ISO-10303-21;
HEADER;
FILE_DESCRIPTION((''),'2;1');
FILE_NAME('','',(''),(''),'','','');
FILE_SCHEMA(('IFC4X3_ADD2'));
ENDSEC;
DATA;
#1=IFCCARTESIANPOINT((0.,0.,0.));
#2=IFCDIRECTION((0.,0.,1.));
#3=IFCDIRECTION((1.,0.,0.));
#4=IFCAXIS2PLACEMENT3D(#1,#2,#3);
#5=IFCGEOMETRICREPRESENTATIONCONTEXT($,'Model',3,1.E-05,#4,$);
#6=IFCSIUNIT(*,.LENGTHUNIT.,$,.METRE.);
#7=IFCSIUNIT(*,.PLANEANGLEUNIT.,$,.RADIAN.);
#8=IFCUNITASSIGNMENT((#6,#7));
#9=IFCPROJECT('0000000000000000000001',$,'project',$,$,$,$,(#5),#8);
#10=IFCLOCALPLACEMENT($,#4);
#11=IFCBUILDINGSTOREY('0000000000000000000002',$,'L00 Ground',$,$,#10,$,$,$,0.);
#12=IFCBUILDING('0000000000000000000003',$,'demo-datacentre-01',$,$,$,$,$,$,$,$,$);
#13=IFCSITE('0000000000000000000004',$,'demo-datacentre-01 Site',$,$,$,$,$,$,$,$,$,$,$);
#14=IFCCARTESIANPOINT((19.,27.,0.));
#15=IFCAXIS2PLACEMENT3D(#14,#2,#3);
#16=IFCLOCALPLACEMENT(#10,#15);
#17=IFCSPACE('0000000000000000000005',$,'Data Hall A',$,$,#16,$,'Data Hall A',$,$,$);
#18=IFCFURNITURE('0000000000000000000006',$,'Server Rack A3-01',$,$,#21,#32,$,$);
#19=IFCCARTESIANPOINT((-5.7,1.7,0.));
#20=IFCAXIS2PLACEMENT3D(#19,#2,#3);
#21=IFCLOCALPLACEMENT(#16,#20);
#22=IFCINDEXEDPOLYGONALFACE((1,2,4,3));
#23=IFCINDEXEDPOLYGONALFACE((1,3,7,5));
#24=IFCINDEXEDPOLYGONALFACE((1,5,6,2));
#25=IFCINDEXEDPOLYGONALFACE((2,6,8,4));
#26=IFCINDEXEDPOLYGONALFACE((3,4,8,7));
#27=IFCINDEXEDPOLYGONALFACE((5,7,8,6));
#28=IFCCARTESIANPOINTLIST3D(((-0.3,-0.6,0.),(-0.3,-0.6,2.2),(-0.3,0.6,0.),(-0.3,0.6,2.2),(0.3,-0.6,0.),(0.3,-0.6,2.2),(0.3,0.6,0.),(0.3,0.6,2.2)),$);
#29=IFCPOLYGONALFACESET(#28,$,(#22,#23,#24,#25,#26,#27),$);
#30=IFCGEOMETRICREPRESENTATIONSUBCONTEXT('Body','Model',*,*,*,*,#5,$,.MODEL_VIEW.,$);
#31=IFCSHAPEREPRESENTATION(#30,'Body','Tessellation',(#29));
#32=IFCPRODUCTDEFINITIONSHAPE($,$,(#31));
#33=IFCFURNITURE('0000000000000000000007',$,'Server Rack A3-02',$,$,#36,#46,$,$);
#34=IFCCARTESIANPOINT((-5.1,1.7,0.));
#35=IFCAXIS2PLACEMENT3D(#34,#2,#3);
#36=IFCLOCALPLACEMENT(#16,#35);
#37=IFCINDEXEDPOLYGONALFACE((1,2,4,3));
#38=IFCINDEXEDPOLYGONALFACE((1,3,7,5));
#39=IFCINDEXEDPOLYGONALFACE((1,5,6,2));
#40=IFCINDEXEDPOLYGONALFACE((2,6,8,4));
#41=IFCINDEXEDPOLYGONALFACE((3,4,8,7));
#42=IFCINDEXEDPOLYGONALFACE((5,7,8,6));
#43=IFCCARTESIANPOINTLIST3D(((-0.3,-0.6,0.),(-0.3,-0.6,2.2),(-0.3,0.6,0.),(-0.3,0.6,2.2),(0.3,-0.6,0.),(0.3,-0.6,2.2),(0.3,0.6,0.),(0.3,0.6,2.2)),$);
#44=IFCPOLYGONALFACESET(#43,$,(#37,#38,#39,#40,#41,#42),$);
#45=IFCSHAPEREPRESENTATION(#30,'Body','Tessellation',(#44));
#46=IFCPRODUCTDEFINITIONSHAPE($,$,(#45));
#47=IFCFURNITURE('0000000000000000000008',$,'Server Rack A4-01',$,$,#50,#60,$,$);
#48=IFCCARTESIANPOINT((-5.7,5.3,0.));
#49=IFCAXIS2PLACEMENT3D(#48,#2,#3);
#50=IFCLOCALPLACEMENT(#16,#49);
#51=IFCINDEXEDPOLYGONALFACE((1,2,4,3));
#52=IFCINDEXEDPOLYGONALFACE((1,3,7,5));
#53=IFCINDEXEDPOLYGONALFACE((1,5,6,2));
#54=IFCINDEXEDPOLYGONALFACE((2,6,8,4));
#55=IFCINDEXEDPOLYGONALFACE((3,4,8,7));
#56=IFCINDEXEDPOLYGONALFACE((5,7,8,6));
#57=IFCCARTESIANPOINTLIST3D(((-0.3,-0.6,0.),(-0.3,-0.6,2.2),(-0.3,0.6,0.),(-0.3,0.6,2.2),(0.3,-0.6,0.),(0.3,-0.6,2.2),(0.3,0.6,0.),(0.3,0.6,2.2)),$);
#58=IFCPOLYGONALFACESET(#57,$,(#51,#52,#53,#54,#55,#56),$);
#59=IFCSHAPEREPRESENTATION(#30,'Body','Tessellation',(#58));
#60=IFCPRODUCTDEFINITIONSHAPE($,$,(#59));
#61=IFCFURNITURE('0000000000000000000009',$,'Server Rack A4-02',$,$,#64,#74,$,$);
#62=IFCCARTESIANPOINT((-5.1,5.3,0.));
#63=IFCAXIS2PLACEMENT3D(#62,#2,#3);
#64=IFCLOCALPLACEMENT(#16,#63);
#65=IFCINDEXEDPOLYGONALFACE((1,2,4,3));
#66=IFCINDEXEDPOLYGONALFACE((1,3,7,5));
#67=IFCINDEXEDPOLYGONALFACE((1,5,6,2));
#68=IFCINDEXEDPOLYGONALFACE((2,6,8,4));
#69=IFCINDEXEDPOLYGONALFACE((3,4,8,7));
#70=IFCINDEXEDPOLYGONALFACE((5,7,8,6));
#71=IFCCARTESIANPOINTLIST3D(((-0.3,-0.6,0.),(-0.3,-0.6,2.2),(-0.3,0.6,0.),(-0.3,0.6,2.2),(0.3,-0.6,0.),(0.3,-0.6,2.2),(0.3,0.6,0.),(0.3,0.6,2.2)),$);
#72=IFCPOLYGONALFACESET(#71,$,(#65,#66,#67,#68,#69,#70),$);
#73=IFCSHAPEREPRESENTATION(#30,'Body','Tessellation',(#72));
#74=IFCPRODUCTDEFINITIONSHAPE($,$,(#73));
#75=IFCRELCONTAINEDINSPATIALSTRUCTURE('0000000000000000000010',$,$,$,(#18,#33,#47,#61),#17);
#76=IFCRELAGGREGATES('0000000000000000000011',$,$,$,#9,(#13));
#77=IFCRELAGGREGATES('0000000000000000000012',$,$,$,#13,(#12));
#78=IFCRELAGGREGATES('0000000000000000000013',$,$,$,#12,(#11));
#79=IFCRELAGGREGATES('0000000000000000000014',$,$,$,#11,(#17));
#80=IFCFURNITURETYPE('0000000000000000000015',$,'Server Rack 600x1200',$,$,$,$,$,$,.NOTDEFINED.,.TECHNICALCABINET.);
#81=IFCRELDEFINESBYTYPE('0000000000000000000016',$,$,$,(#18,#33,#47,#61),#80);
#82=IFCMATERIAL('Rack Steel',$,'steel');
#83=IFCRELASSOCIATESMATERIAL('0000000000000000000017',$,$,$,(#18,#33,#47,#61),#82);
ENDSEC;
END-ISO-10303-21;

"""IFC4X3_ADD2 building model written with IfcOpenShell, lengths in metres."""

from ifc_helpers import new_model, si_unit, frame, origin_with_axes, place, context, subcontext, project, spatial, rectangle, extrude, material, type_object, element, save


model = new_model("IFC4X3_ADD2")

# Units and contexts
model_context = context("Model", 3, precision=1e-05, world=origin_with_axes())
body_context = subcontext(model_context, "Body", "Model", "MODEL_VIEW")
ifc_project = project(units=[si_unit("LENGTHUNIT", "METRE"), si_unit("PLANEANGLEUNIT", "RADIAN")], contexts=[model_context])

# Site, building, storey
site = spatial("IfcSite", under=ifc_project, Name="demo-datacentre-01 Site")
building = spatial("IfcBuilding", under=site, Name="demo-datacentre-01")
storey_placement = place(None, origin_with_axes())
storey = spatial("IfcBuildingStorey", under=building, at=storey_placement, Name="L00 Ground", Elevation=0.0)

# Shared definitions
space_placement = place(storey_placement, frame((19.0, 27.0, 0.0), z_axis=(0.0, 0.0, 1.0), x_axis=(1.0, 0.0, 0.0)))
space = spatial("IfcSpace", under=storey, at=space_placement, Name="Data Hall A", LongName="Data Hall A")

# Furniture
ifc_material_1 = material(Name="Rack Steel", Category="steel")
furniture_type = type_object("IfcFurnitureType", Name="Server Rack 600x1200", AssemblyPlace="NOTDEFINED", PredefinedType="TECHNICALCABINET")
for number, where, z_axis, x_axis, name in (
    (1, (-5.7, 1.7, 0.0), (0.0, 0.0, 1.0), (1.0, 0.0, 0.0), "Server Rack A3-01"),
    (2, (-5.1, 1.7, 0.0), (0.0, 0.0, 1.0), (1.0, 0.0, 0.0), "Server Rack A3-02"),
    (3, (-5.7, 5.3, 0.0), (0.0, 0.0, 1.0), (1.0, 0.0, 0.0), "Server Rack A4-01"),
    (4, (-5.1, 5.3, 0.0), (0.0, 0.0, 1.0), (1.0, 0.0, 0.0), "Server Rack A4-02"),
):
    element("IfcFurniture", number, at=place(space_placement, frame(where, z_axis=z_axis, x_axis=x_axis)), inside=space, type_object=furniture_type, material=ifc_material_1, Name=name, context=body_context, shape_type="SweptSolid", body=[
        extrude(rectangle(XDim=0.6, YDim=1.2), origin_with_axes(), (0.0, 0.0, 1.0), 2.2),
    ])

save(model, "model.ifc")
